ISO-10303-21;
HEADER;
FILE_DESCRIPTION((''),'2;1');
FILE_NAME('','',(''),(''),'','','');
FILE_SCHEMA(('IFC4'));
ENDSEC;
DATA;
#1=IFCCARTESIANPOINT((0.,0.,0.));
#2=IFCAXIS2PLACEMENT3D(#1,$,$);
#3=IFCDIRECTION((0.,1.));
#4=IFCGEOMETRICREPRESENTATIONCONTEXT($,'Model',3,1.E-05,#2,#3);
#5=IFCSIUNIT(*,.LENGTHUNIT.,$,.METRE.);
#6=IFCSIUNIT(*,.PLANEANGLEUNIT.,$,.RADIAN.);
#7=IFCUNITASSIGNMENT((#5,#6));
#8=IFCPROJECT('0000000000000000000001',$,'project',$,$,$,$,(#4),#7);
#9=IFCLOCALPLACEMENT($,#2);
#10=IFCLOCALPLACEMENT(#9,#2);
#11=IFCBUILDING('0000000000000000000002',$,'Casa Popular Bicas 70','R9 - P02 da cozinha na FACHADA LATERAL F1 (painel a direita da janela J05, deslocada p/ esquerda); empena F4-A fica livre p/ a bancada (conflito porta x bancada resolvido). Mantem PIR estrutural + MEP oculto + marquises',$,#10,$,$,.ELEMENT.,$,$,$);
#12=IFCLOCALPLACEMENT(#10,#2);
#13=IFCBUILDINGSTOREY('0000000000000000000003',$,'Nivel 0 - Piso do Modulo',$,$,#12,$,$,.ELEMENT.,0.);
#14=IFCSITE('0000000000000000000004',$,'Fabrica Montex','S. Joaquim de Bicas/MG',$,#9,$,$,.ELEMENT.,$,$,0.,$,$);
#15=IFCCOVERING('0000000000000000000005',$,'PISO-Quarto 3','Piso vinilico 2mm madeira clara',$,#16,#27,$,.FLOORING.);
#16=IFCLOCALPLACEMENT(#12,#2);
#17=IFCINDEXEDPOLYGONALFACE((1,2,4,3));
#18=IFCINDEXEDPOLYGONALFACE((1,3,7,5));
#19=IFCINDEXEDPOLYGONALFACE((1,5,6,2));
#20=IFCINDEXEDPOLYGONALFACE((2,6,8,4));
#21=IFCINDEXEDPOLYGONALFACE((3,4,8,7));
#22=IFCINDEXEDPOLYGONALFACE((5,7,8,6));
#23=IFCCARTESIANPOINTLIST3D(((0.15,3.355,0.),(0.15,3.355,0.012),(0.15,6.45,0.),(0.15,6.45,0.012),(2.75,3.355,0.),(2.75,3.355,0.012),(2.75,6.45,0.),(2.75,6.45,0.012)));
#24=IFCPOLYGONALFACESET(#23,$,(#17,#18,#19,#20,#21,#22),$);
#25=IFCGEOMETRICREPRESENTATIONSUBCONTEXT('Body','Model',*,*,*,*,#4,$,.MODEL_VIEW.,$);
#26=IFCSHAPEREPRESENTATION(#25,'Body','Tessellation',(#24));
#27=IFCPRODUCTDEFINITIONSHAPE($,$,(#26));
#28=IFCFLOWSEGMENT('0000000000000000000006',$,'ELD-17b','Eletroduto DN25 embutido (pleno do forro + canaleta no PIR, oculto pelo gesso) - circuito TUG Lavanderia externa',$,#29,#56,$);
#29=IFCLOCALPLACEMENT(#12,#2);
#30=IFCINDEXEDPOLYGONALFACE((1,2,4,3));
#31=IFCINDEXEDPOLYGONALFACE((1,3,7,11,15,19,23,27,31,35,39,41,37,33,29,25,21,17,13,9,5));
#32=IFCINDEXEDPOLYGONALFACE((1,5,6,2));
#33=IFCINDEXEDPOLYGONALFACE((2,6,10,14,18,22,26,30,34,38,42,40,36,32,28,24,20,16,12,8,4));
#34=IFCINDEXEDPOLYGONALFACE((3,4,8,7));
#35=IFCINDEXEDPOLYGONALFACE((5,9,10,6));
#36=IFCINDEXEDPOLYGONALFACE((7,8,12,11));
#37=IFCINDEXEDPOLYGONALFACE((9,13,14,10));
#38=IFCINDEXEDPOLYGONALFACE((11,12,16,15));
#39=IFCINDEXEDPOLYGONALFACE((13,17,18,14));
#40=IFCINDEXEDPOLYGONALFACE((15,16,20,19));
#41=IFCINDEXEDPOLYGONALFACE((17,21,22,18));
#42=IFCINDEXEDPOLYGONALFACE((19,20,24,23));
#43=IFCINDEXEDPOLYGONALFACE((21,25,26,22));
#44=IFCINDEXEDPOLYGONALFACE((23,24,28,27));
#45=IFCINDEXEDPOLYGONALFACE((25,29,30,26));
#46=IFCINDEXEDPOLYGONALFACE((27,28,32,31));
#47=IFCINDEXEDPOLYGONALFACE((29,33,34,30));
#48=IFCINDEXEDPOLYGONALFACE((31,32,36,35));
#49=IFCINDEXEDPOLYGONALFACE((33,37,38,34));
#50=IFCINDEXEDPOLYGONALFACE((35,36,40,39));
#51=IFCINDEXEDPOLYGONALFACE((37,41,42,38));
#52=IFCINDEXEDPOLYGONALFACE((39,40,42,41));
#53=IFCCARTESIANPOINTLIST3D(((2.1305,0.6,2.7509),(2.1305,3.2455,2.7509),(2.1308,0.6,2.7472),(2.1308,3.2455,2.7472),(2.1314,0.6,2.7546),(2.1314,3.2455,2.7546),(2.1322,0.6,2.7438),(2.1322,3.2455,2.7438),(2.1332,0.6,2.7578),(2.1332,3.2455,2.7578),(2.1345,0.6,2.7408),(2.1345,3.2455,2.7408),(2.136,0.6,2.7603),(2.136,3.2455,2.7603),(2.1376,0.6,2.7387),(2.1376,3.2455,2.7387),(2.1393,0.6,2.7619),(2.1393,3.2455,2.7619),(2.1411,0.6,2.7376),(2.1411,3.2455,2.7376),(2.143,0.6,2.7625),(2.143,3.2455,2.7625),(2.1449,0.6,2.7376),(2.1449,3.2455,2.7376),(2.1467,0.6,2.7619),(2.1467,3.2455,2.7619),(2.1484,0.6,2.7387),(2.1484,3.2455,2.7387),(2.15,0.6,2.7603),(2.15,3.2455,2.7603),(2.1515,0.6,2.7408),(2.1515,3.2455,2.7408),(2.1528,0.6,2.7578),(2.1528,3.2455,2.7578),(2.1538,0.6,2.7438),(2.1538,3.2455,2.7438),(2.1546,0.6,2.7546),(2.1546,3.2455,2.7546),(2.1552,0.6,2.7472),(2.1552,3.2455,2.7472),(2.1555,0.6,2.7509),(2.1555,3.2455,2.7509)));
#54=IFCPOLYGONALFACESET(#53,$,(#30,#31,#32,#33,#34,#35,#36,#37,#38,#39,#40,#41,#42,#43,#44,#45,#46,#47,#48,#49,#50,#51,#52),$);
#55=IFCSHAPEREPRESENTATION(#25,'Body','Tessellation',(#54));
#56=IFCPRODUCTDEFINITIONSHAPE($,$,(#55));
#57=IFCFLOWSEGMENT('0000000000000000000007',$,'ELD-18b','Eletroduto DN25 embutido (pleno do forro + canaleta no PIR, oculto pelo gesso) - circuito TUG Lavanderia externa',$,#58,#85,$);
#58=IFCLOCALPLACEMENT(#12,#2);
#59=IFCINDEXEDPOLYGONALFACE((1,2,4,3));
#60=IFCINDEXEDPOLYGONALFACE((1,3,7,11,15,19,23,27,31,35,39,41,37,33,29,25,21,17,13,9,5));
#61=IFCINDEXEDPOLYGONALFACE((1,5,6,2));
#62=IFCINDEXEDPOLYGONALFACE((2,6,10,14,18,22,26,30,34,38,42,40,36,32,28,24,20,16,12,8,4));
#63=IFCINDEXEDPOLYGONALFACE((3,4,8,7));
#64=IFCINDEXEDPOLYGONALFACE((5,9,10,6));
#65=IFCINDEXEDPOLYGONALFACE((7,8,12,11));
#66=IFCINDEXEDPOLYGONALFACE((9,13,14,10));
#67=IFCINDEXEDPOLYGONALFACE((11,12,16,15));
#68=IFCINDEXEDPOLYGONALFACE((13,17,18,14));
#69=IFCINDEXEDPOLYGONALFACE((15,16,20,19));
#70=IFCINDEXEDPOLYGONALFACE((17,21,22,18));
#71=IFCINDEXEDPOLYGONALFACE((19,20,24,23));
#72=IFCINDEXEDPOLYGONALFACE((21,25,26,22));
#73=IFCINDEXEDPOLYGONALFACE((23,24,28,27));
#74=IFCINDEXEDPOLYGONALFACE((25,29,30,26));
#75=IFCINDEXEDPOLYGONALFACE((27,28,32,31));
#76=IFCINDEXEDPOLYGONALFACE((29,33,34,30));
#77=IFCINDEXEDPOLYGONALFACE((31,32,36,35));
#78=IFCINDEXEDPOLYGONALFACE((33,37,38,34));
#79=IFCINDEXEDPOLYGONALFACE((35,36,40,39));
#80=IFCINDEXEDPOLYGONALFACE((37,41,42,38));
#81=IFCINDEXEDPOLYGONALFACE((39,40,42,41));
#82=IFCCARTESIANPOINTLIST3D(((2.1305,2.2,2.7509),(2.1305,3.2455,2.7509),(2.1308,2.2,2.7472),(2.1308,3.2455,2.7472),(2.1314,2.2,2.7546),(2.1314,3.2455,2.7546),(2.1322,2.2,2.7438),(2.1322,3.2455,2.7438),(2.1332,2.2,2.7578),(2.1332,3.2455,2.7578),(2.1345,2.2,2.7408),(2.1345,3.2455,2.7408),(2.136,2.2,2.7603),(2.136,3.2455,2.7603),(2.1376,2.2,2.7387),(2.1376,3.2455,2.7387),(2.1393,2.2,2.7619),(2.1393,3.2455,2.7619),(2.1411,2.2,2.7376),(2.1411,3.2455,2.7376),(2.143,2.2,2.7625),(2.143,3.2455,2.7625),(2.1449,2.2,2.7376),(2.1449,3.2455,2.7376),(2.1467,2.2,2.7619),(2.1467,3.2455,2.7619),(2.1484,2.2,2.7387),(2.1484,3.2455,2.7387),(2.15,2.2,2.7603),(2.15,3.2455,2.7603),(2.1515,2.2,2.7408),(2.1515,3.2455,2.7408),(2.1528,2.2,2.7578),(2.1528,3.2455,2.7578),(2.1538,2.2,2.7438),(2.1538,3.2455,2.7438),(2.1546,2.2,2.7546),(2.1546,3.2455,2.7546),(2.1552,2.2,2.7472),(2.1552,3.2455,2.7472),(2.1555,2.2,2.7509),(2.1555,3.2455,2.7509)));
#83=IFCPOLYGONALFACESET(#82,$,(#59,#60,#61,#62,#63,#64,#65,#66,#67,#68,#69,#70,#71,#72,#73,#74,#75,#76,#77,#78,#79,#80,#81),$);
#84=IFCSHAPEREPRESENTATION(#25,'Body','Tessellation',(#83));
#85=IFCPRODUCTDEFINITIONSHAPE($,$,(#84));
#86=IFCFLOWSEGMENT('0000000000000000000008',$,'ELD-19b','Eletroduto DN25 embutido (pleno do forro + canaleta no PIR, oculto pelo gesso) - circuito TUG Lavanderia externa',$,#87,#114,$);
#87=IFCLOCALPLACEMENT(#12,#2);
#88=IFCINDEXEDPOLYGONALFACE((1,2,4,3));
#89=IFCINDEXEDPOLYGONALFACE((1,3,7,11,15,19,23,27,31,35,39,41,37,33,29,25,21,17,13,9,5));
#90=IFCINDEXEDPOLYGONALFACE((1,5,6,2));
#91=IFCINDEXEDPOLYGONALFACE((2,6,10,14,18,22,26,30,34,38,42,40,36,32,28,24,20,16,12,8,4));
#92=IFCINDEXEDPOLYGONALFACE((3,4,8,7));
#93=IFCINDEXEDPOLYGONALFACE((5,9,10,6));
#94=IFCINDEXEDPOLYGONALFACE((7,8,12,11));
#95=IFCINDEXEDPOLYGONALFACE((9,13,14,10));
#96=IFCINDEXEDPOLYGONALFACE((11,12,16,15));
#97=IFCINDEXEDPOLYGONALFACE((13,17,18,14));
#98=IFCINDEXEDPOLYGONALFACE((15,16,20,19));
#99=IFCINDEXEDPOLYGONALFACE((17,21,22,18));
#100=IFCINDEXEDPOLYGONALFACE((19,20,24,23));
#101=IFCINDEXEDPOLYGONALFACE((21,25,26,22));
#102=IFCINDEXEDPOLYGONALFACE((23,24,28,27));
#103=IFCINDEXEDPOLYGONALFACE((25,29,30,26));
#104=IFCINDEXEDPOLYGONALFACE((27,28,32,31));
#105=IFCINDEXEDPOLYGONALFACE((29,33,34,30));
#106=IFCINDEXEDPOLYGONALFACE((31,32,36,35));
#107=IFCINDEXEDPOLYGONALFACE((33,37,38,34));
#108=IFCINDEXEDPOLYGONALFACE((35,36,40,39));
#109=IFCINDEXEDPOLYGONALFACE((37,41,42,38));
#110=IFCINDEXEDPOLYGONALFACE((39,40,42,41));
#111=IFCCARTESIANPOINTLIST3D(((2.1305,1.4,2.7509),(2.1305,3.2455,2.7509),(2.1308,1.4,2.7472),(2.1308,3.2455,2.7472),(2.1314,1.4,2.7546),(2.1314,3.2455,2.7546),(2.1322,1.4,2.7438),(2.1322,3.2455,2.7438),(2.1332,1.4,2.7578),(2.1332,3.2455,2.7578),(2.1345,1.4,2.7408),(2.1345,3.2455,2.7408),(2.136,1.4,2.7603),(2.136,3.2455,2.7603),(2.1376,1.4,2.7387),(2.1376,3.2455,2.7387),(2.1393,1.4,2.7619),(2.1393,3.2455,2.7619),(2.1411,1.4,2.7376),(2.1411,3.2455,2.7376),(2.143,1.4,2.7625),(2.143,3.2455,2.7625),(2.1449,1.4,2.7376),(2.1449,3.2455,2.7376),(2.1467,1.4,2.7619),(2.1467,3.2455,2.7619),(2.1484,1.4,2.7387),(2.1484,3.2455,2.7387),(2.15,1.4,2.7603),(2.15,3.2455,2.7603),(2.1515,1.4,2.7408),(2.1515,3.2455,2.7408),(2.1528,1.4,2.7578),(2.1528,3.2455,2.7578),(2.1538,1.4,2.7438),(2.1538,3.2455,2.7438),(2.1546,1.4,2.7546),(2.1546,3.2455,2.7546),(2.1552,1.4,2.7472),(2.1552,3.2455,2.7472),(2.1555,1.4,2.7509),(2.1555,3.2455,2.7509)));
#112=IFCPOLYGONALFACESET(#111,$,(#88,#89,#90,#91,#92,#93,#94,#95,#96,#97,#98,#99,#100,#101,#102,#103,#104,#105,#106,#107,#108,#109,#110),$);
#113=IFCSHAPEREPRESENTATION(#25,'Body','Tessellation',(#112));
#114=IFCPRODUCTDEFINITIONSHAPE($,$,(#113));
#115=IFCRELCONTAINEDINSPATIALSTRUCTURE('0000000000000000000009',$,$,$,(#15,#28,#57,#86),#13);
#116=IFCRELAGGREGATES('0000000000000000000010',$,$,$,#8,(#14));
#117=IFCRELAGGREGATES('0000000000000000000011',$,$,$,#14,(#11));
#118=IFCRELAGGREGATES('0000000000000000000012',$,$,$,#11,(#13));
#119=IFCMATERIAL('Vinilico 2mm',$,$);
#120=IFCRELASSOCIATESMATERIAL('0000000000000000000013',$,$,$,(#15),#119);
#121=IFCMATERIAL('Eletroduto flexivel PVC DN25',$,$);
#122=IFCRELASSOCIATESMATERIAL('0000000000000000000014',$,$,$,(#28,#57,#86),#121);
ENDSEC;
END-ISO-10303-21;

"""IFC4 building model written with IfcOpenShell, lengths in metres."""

from ifc_helpers import new_model, si_unit, direction, frame, frame_2d, origin, origin_2d, place, context, subcontext, project, spatial, rectangle, circle, extrude, material, element, save


model = new_model("IFC4")

# Units and contexts
model_context = context("Model", 3, precision=1e-05, world=origin(), true_north=direction((0.0, 1.0)))
body_context = subcontext(model_context, "Body", "Model", "MODEL_VIEW")
ifc_project = project(units=[si_unit("LENGTHUNIT", "METRE"), si_unit("PLANEANGLEUNIT", "RADIAN")], contexts=[model_context])

# Site, building, storey
site_placement = place(None, origin())
site = spatial("IfcSite", under=ifc_project, at=site_placement, Name="Fabrica Montex", Description="S. Joaquim de Bicas/MG", CompositionType="ELEMENT", RefElevation=0.0)
building_placement = place(site_placement, origin())
building = spatial("IfcBuilding", under=site, at=building_placement, Name="Casa Popular Bicas 70", Description="R9 - P02 da cozinha na FACHADA LATERAL F1 (painel a direita da janela J05, deslocada p/ esquerda); empena F4-A fica livre p/ a bancada (conflito porta x bancada resolvido). Mantem PIR estrutural + MEP oculto + marquises", CompositionType="ELEMENT")
storey_placement = place(building_placement, origin())
storey = spatial("IfcBuildingStorey", under=building, at=storey_placement, Name="Nivel 0 - Piso do Modulo", CompositionType="ELEMENT", Elevation=0.0)

# Covering
ifc_material_1 = material(Name="Vinilico 2mm")
covering_1_placement = place(storey_placement, frame((0.15, 3.355, 0.0)))
element("IfcCovering", 1, at=covering_1_placement, inside=storey, material=ifc_material_1, Name="PISO-Quarto 3", Description="Piso vinilico 2mm madeira clara", PredefinedType="FLOORING", context=body_context, shape_type="SweptSolid", body=[
    extrude(rectangle(XDim=2.6, YDim=3.095, at=frame_2d((1.3, 1.5475))), origin(), (0.0, 0.0, 1.0), 0.012),
])

# Flow segments
ifc_material_2 = material(Name="Eletroduto flexivel PVC DN25")
flow_segment_1_placement = place(storey_placement, frame((2.143, 3.2455, 2.75), z_axis=(0.0, -1.0, 0.0), x_axis=(0.0, 0.0, 1.0)))
element("IfcFlowSegment", 2, at=flow_segment_1_placement, inside=storey, material=ifc_material_2, Name="ELD-17b", Description="Eletroduto DN25 embutido (pleno do forro + canaleta no PIR, oculto pelo gesso) - circuito TUG Lavanderia externa", context=body_context, shape_type="SweptSolid", body=[
    extrude(circle(Radius=0.0125, at=origin_2d()), origin(), (0.0, 0.0, 1.0), 2.6455),
])
flow_segment_2_placement = place(storey_placement, frame((2.143, 3.2455, 2.75), z_axis=(0.0, -1.0, 0.0), x_axis=(0.0, 0.0, 1.0)))
element("IfcFlowSegment", 3, at=flow_segment_2_placement, inside=storey, material=ifc_material_2, Name="ELD-18b", Description="Eletroduto DN25 embutido (pleno do forro + canaleta no PIR, oculto pelo gesso) - circuito TUG Lavanderia externa", context=body_context, shape_type="SweptSolid", body=[
    extrude(circle(Radius=0.0125, at=origin_2d()), origin(), (0.0, 0.0, 1.0), 1.0455),
])
flow_segment_3_placement = place(storey_placement, frame((2.143, 3.2455, 2.75), z_axis=(0.0, -1.0, 0.0), x_axis=(0.0, 0.0, 1.0)))
element("IfcFlowSegment", 4, at=flow_segment_3_placement, inside=storey, material=ifc_material_2, Name="ELD-19b", Description="Eletroduto DN25 embutido (pleno do forro + canaleta no PIR, oculto pelo gesso) - circuito TUG Lavanderia externa", context=body_context, shape_type="SweptSolid", body=[
    extrude(circle(Radius=0.0125, at=origin_2d()), origin(), (0.0, 0.0, 1.0), 1.8455),
])

save(model, "model.ifc")
